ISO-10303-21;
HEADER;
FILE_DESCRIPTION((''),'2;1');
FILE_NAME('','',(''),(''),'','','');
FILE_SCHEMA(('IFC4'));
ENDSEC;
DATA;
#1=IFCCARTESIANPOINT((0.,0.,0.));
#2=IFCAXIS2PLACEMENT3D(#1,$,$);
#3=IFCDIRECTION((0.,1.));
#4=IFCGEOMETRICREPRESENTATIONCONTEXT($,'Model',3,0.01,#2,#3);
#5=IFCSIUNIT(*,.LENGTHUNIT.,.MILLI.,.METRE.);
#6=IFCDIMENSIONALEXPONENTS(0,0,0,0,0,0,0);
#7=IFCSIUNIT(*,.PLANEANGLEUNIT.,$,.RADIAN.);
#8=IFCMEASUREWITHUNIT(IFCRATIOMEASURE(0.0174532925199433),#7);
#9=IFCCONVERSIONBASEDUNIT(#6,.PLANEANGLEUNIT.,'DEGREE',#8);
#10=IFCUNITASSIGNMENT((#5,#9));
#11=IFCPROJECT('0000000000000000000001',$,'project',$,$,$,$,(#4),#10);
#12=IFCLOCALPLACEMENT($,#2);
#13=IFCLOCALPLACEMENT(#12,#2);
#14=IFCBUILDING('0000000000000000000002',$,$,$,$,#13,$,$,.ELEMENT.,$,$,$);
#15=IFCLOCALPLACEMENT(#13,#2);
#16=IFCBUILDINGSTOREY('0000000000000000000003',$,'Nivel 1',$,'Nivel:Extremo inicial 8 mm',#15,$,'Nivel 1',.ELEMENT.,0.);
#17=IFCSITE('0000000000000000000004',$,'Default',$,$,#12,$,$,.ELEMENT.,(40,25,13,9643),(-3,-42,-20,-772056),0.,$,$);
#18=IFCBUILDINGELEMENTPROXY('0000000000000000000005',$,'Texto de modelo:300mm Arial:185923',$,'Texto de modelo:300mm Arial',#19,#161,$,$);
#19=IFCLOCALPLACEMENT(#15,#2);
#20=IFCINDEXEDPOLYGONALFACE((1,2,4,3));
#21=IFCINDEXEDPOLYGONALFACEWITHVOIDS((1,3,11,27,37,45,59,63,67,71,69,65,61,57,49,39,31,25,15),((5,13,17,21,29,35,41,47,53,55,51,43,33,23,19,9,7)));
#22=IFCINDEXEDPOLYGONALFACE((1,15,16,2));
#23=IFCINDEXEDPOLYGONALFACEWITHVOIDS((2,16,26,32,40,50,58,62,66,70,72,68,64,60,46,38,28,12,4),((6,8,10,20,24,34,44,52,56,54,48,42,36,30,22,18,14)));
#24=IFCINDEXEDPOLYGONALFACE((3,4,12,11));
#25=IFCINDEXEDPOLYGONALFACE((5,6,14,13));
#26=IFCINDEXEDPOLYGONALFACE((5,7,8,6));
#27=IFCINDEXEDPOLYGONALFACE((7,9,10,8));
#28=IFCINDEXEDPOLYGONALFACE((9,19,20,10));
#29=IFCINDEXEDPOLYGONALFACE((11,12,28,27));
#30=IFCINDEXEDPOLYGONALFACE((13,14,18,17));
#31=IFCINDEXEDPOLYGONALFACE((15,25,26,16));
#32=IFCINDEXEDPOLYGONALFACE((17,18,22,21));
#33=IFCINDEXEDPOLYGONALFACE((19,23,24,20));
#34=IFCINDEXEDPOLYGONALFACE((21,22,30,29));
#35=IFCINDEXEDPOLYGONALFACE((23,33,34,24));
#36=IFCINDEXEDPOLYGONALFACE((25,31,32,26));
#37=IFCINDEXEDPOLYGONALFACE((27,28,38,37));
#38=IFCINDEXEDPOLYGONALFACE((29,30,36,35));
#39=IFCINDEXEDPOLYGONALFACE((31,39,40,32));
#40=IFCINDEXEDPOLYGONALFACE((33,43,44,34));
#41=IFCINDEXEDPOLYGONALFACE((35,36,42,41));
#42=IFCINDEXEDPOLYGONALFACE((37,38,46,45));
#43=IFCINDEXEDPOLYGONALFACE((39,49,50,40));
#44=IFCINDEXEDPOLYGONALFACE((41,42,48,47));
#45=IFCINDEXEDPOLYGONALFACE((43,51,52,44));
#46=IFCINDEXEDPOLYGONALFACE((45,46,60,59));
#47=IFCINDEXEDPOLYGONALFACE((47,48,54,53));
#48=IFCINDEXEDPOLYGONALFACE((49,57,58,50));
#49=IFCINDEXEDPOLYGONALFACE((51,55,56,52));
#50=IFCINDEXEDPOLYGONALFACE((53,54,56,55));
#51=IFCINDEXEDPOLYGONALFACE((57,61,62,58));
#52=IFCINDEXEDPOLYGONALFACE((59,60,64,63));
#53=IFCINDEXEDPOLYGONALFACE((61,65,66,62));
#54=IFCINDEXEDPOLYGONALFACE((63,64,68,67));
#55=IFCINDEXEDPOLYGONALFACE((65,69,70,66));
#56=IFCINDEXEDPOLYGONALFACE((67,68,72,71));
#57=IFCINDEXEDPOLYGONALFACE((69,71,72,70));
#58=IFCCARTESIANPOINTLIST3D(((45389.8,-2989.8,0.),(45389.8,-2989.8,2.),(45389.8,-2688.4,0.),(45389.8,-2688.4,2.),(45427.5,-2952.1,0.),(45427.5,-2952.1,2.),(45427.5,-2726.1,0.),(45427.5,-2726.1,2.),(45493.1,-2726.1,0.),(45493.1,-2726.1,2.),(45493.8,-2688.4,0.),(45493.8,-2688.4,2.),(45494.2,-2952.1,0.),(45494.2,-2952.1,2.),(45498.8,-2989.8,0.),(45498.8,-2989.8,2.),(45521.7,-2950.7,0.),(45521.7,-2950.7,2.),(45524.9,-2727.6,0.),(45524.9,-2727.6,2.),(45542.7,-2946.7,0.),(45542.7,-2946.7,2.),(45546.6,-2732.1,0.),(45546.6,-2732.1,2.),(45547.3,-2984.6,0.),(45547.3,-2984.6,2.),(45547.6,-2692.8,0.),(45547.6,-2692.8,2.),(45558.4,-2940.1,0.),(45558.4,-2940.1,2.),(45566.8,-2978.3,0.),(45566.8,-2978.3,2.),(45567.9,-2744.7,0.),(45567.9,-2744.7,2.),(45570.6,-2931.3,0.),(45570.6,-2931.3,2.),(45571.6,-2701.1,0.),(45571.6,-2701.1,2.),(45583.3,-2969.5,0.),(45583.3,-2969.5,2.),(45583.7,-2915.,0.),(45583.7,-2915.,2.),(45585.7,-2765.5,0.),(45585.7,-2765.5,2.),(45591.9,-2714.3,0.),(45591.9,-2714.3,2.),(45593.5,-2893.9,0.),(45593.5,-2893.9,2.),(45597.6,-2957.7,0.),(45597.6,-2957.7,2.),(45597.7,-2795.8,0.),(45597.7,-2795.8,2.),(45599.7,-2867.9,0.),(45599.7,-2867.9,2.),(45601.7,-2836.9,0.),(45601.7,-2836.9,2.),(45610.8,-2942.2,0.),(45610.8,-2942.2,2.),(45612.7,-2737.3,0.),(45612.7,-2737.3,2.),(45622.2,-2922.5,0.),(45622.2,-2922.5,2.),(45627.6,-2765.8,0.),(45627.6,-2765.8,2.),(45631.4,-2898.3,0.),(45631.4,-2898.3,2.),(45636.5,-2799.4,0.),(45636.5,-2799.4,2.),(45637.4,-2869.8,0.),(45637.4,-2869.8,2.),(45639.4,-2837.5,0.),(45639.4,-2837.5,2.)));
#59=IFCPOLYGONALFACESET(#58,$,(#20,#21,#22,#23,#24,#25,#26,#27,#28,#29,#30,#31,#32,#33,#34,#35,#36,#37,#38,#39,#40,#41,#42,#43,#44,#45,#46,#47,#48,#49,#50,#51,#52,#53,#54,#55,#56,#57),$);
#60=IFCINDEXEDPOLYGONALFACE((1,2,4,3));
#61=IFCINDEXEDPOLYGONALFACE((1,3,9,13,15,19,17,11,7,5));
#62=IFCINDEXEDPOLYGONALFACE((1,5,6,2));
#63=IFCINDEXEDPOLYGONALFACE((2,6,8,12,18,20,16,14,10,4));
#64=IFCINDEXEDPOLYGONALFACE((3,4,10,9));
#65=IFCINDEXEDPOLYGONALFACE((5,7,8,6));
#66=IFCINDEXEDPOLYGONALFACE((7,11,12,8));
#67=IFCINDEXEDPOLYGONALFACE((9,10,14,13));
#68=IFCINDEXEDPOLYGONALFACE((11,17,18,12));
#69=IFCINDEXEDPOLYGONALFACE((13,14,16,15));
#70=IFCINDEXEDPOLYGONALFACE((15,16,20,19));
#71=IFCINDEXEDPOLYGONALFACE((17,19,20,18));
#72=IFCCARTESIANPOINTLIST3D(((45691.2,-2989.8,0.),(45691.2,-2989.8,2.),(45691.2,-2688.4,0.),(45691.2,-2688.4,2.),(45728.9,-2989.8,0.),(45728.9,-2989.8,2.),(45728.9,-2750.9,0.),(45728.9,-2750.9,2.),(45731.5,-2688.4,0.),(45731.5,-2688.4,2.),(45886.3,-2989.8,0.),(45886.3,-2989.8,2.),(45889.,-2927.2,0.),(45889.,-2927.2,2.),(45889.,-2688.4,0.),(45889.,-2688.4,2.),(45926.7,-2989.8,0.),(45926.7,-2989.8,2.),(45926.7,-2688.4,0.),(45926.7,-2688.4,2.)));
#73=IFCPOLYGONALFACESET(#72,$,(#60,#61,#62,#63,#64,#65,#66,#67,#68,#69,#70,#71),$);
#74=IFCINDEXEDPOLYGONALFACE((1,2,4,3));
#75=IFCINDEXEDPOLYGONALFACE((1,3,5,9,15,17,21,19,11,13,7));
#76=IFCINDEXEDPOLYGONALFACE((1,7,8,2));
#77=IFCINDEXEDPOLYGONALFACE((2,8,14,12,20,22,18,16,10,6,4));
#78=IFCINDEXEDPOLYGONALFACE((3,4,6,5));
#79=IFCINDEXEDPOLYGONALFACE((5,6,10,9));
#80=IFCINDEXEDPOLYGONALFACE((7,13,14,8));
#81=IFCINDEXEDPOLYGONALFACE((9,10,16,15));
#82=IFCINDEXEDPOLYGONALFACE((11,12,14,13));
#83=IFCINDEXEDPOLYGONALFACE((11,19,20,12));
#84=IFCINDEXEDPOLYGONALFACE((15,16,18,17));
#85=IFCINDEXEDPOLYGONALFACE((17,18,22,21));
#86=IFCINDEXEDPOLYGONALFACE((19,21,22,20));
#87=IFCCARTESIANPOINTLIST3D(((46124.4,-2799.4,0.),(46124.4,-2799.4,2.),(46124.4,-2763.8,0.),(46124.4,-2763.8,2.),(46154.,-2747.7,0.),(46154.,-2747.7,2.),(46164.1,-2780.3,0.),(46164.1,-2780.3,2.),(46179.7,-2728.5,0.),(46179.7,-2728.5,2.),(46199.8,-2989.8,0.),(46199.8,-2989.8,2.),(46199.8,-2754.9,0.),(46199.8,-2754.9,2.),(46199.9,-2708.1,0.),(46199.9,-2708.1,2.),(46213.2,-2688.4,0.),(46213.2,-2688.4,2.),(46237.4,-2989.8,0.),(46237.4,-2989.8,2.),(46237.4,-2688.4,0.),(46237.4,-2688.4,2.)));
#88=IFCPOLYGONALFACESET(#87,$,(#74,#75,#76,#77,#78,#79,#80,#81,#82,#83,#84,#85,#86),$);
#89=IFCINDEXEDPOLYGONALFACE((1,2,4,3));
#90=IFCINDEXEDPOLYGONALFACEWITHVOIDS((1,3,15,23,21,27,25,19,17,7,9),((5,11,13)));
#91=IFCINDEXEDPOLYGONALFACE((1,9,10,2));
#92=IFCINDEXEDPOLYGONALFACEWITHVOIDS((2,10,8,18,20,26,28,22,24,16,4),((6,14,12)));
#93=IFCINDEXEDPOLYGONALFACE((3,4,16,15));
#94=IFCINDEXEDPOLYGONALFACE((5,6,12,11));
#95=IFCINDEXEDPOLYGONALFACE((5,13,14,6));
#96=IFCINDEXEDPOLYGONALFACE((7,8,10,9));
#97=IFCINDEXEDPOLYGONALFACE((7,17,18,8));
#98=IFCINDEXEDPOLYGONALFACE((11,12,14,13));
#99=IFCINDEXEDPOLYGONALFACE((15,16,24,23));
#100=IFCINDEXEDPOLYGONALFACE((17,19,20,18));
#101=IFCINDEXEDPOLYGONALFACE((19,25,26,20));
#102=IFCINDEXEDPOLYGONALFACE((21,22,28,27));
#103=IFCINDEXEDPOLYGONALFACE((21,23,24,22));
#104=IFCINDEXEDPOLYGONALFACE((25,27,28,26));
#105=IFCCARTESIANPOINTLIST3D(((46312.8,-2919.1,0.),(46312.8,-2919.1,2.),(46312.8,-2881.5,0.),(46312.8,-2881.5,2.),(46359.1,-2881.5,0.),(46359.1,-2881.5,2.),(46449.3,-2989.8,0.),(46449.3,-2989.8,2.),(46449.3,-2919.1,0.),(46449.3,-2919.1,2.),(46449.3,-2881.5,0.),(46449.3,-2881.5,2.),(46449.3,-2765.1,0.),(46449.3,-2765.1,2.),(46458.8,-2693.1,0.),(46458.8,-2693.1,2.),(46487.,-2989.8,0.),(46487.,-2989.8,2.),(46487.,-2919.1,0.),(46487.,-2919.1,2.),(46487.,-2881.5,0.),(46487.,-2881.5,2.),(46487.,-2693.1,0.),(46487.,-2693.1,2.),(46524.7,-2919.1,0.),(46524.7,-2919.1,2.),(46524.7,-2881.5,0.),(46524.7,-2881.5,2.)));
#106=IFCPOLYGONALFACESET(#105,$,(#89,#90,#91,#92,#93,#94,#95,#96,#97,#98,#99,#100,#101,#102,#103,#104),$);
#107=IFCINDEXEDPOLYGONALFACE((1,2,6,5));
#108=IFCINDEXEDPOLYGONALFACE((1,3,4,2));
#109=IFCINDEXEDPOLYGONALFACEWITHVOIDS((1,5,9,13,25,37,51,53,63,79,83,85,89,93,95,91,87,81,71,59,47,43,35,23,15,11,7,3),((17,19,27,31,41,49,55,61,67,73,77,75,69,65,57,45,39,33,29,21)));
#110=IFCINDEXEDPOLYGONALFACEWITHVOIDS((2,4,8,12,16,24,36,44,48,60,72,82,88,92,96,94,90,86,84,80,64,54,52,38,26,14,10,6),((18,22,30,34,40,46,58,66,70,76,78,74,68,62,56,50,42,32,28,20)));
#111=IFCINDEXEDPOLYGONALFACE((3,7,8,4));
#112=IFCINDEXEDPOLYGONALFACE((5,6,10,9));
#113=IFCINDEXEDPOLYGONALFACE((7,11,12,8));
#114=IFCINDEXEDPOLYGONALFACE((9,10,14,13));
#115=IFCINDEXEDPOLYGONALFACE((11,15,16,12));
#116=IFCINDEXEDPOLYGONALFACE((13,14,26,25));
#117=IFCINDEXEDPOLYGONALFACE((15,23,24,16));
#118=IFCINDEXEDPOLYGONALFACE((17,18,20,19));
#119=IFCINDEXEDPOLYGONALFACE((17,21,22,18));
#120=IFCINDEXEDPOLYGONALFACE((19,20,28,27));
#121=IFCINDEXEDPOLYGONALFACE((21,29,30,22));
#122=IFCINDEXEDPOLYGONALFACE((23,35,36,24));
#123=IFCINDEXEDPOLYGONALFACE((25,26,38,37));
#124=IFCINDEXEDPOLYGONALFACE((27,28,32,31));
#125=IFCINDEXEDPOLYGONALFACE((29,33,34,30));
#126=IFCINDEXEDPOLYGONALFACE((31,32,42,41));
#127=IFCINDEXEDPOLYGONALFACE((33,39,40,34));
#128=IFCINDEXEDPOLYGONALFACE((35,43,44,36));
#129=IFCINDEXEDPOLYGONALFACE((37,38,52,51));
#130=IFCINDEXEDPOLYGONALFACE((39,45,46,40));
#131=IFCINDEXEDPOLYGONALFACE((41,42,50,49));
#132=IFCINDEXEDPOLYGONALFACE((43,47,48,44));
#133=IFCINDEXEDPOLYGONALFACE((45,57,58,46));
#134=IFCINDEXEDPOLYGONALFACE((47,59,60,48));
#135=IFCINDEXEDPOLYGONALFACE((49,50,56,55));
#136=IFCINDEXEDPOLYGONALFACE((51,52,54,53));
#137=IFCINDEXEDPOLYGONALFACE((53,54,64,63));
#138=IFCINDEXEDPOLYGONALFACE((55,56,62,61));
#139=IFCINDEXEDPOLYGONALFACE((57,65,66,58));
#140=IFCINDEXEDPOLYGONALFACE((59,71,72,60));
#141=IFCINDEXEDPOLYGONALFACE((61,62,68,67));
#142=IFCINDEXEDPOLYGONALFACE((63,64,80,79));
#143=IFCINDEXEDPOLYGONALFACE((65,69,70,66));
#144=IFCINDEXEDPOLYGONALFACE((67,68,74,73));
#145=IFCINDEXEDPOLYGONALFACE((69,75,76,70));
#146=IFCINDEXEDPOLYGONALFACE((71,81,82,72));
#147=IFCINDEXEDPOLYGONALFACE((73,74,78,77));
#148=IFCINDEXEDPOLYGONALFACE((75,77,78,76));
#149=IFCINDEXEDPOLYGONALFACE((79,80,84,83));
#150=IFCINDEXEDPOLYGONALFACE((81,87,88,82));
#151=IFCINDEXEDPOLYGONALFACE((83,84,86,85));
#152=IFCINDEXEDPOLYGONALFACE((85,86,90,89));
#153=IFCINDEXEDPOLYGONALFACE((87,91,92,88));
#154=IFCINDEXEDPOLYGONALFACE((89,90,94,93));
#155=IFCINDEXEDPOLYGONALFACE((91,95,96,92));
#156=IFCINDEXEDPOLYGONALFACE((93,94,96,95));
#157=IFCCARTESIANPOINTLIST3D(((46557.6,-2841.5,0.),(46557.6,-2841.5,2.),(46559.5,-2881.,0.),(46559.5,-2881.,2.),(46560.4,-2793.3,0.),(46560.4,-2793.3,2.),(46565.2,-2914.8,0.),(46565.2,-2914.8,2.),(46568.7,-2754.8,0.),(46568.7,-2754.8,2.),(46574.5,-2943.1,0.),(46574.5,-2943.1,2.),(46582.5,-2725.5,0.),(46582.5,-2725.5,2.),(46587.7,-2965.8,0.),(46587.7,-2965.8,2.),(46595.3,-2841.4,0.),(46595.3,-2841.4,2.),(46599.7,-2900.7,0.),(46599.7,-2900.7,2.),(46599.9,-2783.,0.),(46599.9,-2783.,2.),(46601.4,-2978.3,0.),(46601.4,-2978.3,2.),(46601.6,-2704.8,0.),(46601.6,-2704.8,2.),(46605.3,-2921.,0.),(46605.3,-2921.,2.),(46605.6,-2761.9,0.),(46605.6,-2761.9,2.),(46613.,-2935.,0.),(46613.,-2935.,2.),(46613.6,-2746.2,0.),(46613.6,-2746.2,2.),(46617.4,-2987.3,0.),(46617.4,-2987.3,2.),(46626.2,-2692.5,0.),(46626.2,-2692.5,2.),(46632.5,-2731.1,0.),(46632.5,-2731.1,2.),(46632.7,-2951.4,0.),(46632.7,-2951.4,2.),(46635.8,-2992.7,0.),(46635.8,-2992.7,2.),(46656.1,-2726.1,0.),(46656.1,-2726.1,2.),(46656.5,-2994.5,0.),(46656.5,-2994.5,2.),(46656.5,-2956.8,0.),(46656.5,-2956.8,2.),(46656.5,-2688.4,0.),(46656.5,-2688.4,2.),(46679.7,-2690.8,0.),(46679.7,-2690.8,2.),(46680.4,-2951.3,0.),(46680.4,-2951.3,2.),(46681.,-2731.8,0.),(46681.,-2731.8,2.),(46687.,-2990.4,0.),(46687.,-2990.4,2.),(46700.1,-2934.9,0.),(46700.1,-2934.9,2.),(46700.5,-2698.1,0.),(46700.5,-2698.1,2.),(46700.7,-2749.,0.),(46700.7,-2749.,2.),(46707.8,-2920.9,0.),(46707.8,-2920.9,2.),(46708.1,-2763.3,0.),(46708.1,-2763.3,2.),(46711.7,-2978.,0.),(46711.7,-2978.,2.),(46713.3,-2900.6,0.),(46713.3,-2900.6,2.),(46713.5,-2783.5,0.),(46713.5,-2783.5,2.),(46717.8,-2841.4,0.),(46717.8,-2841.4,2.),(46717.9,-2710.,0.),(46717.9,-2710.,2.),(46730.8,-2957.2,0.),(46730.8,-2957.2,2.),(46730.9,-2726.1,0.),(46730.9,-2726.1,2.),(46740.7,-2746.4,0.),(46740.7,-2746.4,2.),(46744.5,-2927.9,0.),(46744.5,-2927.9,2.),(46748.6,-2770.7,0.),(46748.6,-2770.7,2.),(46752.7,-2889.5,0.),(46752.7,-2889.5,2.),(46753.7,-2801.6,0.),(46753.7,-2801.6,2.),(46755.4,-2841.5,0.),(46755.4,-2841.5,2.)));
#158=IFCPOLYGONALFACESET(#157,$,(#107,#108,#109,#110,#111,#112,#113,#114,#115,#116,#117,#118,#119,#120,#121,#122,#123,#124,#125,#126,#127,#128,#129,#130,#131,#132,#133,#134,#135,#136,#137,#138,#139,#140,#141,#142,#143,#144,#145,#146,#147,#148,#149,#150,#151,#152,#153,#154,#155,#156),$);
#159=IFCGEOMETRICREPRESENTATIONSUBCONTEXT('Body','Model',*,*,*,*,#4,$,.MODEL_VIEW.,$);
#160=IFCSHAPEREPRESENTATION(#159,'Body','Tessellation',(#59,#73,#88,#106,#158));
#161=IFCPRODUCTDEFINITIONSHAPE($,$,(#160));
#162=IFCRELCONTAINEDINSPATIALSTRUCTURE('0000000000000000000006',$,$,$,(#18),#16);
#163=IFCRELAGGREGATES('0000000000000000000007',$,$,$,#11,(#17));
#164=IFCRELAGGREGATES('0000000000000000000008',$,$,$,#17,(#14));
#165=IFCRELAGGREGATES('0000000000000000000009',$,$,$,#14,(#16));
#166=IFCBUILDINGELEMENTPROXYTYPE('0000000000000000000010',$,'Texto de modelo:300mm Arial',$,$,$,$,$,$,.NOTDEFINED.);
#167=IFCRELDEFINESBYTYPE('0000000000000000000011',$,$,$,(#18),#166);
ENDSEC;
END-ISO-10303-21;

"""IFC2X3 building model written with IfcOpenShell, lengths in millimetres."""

from ifc_helpers import new_model, entity, si_unit, converted_unit, direction, frame, origin, place, context, subcontext, project, spatial, polyline, outline, extrude, type_object, element, save


model = new_model("IFC2X3")

# Units and contexts
model_context = context("Model", 3, precision=0.01, world=origin(), true_north=direction((0.0, 1.0)))
body_context = subcontext(model_context, "Body", "Model", "MODEL_VIEW")
ifc_project = project(units=[si_unit("LENGTHUNIT", "METRE", prefix="MILLI"), converted_unit("PLANEANGLEUNIT", "DEGREE", entity("IfcRatioMeasure", 0.0174532925199433), si_unit("PLANEANGLEUNIT", "RADIAN"), dimensions=[0, 0, 0, 0, 0, 0, 0])], contexts=[model_context])

# Site, building, storey
site_placement = place(None, origin())
site = spatial("IfcSite", under=ifc_project, at=site_placement, Name="Default", CompositionType="ELEMENT", RefLatitude=(40, 25, 13, 9643), RefLongitude=(-3, -42, -20, -772056), RefElevation=0.0)
building_placement = place(site_placement, origin())
building = spatial("IfcBuilding", under=site, at=building_placement, CompositionType="ELEMENT")
storey_placement = place(building_placement, origin())
storey = spatial("IfcBuildingStorey", under=building, at=storey_placement, Name="Nivel 1", ObjectType="Nivel:Extremo inicial 8 mm", LongName="Nivel 1", CompositionType="ELEMENT", Elevation=0.0)

# Building element proxy
building_element_proxy_type_1 = type_object("IfcBuildingElementProxyType", Name="Texto de modelo:300mm Arial", PredefinedType="NOTDEFINED")
proxy_1_placement = place(storey_placement, frame((45389.8, -2994.5, 0.0)))
element("IfcBuildingElementProxy", 1, at=proxy_1_placement, inside=storey, type_object=building_element_proxy_type_1, Name="Texto de modelo:300mm Arial:185923", ObjectType="Texto de modelo:300mm Arial", context=body_context, shape_type="SweptSolid", body=[
    extrude(outline(polyline([(-178.4, -141.0), (-69.4, -141.0), (-21.0, -135.8), (-1.4, -129.5), (15.0, -120.7), (29.4, -108.9), (42.6, -93.4), (54.0, -73.7), (63.2, -49.5), (69.2, -21.0), (71.2, 11.3), (68.2, 49.4), (59.3, 83.0), (44.5, 111.5), (23.7, 134.5), (3.4, 147.7), (-20.6, 156.1), (-74.4, 160.4), (-178.4, 160.4), (-178.4, -141.0)]), holes=[polyline([(-140.7, -103.3), (-140.7, 122.7), (-75.1, 122.7), (-43.3, 121.2), (-21.7, 116.7), (-0.4, 104.1), (17.4, 83.3), (29.5, 53.0), (33.5, 11.9), (31.5, -19.1), (25.3, -45.1), (15.5, -66.2), (2.4, -82.5), (-9.8, -91.3), (-25.6, -97.9), (-46.5, -101.9), (-74.1, -103.3), (-140.7, -103.3)])]), frame((178.4, 145.7, 0.0)), (0.0, 0.0, 1.0), 2.0),
    extrude(outline(polyline([(-117.7, -150.7), (-80.1, -150.7), (-80.1, 88.1), (77.4, -150.7), (117.7, -150.7), (117.7, 150.7), (80.1, 150.7), (80.1, -88.1), (-77.4, 150.7), (-117.7, 150.7), (-117.7, -150.7)])), frame((419.1, 155.4, 0.0)), (0.0, 0.0, 1.0), 2.0),
    extrude(outline(polyline([(-204.4, -52.5), (97.0, -52.5), (97.0, -28.2), (77.2, -14.9), (56.9, 5.3), (37.7, 30.9), (21.6, 60.5), (-14.0, 60.5), (5.0, 20.8), (30.4, -14.9), (-204.4, -14.9), (-204.4, -52.5)])), frame((795.1, 209.1, 0.0), z_axis=(0.0, 0.0, 1.0), x_axis=(0.0, 1.0, 0.0)), (0.0, 0.0, 1.0), 2.0),
    extrude(outline(polyline([(-3.4, -109.2), (34.2, -109.2), (34.2, -38.5), (71.9, -38.5), (71.9, -0.9), (34.2, -0.9), (34.2, 187.5), (6.0, 187.5), (-140.0, -0.9), (-140.0, -38.5), (-3.4, -38.5), (-3.4, -109.2)]), holes=[polyline([(-3.4, -0.9), (-93.6, -0.9), (-3.4, 115.5), (-3.4, -0.9)])]), frame((1062.9, 113.9, 0.0)), (0.0, 0.0, 1.0), 2.0),
    extrude(outline(polyline([(-5.6, -99.5), (33.9, -99.5), (68.0, -95.5), (96.7, -87.5), (120.0, -75.5), (133.2, -62.4), (142.9, -46.8), (149.1, -28.7), (151.9, -8.0), (149.2, 22.6), (138.0, 47.8), (118.2, 67.9), (89.5, 82.9), (51.6, 93.0), (3.8, 98.0), (-36.2, 98.2), (-67.3, 94.5), (-91.9, 87.9), (-112.6, 79.0), (-129.4, 66.8), (-142.0, 50.0), (-150.3, 29.6), (-153.8, 6.5), (-151.2, -23.9), (-140.1, -49.1), (-120.3, -69.2), (-91.7, -84.4), (-53.6, -94.5), (-5.6, -99.5)]), holes=[polyline([(-3.9, -61.9), (-62.1, -54.6), (-82.9, -47.9), (-98.1, -39.2), (-112.3, -19.5), (-116.2, 4.3), (-109.3, 28.9), (-91.2, 47.7), (-76.5, 54.5), (-56.1, 58.9), (1.9, 60.4), (60.8, 53.2), (80.8, 46.7), (94.5, 38.3), (109.9, 17.8), (114.3, -6.3), (107.7, -29.8), (90.4, -48.7), (76.0, -55.8), (55.5, -60.3), (-3.9, -61.9)])]), frame((1267.5, 152.1, 0.0), z_axis=(0.0, 0.0, 1.0), x_axis=(0.047515, -0.998871, 0.0)), (0.0, 0.0, 1.0), 2.0),
])

save(model, "model.ifc")
